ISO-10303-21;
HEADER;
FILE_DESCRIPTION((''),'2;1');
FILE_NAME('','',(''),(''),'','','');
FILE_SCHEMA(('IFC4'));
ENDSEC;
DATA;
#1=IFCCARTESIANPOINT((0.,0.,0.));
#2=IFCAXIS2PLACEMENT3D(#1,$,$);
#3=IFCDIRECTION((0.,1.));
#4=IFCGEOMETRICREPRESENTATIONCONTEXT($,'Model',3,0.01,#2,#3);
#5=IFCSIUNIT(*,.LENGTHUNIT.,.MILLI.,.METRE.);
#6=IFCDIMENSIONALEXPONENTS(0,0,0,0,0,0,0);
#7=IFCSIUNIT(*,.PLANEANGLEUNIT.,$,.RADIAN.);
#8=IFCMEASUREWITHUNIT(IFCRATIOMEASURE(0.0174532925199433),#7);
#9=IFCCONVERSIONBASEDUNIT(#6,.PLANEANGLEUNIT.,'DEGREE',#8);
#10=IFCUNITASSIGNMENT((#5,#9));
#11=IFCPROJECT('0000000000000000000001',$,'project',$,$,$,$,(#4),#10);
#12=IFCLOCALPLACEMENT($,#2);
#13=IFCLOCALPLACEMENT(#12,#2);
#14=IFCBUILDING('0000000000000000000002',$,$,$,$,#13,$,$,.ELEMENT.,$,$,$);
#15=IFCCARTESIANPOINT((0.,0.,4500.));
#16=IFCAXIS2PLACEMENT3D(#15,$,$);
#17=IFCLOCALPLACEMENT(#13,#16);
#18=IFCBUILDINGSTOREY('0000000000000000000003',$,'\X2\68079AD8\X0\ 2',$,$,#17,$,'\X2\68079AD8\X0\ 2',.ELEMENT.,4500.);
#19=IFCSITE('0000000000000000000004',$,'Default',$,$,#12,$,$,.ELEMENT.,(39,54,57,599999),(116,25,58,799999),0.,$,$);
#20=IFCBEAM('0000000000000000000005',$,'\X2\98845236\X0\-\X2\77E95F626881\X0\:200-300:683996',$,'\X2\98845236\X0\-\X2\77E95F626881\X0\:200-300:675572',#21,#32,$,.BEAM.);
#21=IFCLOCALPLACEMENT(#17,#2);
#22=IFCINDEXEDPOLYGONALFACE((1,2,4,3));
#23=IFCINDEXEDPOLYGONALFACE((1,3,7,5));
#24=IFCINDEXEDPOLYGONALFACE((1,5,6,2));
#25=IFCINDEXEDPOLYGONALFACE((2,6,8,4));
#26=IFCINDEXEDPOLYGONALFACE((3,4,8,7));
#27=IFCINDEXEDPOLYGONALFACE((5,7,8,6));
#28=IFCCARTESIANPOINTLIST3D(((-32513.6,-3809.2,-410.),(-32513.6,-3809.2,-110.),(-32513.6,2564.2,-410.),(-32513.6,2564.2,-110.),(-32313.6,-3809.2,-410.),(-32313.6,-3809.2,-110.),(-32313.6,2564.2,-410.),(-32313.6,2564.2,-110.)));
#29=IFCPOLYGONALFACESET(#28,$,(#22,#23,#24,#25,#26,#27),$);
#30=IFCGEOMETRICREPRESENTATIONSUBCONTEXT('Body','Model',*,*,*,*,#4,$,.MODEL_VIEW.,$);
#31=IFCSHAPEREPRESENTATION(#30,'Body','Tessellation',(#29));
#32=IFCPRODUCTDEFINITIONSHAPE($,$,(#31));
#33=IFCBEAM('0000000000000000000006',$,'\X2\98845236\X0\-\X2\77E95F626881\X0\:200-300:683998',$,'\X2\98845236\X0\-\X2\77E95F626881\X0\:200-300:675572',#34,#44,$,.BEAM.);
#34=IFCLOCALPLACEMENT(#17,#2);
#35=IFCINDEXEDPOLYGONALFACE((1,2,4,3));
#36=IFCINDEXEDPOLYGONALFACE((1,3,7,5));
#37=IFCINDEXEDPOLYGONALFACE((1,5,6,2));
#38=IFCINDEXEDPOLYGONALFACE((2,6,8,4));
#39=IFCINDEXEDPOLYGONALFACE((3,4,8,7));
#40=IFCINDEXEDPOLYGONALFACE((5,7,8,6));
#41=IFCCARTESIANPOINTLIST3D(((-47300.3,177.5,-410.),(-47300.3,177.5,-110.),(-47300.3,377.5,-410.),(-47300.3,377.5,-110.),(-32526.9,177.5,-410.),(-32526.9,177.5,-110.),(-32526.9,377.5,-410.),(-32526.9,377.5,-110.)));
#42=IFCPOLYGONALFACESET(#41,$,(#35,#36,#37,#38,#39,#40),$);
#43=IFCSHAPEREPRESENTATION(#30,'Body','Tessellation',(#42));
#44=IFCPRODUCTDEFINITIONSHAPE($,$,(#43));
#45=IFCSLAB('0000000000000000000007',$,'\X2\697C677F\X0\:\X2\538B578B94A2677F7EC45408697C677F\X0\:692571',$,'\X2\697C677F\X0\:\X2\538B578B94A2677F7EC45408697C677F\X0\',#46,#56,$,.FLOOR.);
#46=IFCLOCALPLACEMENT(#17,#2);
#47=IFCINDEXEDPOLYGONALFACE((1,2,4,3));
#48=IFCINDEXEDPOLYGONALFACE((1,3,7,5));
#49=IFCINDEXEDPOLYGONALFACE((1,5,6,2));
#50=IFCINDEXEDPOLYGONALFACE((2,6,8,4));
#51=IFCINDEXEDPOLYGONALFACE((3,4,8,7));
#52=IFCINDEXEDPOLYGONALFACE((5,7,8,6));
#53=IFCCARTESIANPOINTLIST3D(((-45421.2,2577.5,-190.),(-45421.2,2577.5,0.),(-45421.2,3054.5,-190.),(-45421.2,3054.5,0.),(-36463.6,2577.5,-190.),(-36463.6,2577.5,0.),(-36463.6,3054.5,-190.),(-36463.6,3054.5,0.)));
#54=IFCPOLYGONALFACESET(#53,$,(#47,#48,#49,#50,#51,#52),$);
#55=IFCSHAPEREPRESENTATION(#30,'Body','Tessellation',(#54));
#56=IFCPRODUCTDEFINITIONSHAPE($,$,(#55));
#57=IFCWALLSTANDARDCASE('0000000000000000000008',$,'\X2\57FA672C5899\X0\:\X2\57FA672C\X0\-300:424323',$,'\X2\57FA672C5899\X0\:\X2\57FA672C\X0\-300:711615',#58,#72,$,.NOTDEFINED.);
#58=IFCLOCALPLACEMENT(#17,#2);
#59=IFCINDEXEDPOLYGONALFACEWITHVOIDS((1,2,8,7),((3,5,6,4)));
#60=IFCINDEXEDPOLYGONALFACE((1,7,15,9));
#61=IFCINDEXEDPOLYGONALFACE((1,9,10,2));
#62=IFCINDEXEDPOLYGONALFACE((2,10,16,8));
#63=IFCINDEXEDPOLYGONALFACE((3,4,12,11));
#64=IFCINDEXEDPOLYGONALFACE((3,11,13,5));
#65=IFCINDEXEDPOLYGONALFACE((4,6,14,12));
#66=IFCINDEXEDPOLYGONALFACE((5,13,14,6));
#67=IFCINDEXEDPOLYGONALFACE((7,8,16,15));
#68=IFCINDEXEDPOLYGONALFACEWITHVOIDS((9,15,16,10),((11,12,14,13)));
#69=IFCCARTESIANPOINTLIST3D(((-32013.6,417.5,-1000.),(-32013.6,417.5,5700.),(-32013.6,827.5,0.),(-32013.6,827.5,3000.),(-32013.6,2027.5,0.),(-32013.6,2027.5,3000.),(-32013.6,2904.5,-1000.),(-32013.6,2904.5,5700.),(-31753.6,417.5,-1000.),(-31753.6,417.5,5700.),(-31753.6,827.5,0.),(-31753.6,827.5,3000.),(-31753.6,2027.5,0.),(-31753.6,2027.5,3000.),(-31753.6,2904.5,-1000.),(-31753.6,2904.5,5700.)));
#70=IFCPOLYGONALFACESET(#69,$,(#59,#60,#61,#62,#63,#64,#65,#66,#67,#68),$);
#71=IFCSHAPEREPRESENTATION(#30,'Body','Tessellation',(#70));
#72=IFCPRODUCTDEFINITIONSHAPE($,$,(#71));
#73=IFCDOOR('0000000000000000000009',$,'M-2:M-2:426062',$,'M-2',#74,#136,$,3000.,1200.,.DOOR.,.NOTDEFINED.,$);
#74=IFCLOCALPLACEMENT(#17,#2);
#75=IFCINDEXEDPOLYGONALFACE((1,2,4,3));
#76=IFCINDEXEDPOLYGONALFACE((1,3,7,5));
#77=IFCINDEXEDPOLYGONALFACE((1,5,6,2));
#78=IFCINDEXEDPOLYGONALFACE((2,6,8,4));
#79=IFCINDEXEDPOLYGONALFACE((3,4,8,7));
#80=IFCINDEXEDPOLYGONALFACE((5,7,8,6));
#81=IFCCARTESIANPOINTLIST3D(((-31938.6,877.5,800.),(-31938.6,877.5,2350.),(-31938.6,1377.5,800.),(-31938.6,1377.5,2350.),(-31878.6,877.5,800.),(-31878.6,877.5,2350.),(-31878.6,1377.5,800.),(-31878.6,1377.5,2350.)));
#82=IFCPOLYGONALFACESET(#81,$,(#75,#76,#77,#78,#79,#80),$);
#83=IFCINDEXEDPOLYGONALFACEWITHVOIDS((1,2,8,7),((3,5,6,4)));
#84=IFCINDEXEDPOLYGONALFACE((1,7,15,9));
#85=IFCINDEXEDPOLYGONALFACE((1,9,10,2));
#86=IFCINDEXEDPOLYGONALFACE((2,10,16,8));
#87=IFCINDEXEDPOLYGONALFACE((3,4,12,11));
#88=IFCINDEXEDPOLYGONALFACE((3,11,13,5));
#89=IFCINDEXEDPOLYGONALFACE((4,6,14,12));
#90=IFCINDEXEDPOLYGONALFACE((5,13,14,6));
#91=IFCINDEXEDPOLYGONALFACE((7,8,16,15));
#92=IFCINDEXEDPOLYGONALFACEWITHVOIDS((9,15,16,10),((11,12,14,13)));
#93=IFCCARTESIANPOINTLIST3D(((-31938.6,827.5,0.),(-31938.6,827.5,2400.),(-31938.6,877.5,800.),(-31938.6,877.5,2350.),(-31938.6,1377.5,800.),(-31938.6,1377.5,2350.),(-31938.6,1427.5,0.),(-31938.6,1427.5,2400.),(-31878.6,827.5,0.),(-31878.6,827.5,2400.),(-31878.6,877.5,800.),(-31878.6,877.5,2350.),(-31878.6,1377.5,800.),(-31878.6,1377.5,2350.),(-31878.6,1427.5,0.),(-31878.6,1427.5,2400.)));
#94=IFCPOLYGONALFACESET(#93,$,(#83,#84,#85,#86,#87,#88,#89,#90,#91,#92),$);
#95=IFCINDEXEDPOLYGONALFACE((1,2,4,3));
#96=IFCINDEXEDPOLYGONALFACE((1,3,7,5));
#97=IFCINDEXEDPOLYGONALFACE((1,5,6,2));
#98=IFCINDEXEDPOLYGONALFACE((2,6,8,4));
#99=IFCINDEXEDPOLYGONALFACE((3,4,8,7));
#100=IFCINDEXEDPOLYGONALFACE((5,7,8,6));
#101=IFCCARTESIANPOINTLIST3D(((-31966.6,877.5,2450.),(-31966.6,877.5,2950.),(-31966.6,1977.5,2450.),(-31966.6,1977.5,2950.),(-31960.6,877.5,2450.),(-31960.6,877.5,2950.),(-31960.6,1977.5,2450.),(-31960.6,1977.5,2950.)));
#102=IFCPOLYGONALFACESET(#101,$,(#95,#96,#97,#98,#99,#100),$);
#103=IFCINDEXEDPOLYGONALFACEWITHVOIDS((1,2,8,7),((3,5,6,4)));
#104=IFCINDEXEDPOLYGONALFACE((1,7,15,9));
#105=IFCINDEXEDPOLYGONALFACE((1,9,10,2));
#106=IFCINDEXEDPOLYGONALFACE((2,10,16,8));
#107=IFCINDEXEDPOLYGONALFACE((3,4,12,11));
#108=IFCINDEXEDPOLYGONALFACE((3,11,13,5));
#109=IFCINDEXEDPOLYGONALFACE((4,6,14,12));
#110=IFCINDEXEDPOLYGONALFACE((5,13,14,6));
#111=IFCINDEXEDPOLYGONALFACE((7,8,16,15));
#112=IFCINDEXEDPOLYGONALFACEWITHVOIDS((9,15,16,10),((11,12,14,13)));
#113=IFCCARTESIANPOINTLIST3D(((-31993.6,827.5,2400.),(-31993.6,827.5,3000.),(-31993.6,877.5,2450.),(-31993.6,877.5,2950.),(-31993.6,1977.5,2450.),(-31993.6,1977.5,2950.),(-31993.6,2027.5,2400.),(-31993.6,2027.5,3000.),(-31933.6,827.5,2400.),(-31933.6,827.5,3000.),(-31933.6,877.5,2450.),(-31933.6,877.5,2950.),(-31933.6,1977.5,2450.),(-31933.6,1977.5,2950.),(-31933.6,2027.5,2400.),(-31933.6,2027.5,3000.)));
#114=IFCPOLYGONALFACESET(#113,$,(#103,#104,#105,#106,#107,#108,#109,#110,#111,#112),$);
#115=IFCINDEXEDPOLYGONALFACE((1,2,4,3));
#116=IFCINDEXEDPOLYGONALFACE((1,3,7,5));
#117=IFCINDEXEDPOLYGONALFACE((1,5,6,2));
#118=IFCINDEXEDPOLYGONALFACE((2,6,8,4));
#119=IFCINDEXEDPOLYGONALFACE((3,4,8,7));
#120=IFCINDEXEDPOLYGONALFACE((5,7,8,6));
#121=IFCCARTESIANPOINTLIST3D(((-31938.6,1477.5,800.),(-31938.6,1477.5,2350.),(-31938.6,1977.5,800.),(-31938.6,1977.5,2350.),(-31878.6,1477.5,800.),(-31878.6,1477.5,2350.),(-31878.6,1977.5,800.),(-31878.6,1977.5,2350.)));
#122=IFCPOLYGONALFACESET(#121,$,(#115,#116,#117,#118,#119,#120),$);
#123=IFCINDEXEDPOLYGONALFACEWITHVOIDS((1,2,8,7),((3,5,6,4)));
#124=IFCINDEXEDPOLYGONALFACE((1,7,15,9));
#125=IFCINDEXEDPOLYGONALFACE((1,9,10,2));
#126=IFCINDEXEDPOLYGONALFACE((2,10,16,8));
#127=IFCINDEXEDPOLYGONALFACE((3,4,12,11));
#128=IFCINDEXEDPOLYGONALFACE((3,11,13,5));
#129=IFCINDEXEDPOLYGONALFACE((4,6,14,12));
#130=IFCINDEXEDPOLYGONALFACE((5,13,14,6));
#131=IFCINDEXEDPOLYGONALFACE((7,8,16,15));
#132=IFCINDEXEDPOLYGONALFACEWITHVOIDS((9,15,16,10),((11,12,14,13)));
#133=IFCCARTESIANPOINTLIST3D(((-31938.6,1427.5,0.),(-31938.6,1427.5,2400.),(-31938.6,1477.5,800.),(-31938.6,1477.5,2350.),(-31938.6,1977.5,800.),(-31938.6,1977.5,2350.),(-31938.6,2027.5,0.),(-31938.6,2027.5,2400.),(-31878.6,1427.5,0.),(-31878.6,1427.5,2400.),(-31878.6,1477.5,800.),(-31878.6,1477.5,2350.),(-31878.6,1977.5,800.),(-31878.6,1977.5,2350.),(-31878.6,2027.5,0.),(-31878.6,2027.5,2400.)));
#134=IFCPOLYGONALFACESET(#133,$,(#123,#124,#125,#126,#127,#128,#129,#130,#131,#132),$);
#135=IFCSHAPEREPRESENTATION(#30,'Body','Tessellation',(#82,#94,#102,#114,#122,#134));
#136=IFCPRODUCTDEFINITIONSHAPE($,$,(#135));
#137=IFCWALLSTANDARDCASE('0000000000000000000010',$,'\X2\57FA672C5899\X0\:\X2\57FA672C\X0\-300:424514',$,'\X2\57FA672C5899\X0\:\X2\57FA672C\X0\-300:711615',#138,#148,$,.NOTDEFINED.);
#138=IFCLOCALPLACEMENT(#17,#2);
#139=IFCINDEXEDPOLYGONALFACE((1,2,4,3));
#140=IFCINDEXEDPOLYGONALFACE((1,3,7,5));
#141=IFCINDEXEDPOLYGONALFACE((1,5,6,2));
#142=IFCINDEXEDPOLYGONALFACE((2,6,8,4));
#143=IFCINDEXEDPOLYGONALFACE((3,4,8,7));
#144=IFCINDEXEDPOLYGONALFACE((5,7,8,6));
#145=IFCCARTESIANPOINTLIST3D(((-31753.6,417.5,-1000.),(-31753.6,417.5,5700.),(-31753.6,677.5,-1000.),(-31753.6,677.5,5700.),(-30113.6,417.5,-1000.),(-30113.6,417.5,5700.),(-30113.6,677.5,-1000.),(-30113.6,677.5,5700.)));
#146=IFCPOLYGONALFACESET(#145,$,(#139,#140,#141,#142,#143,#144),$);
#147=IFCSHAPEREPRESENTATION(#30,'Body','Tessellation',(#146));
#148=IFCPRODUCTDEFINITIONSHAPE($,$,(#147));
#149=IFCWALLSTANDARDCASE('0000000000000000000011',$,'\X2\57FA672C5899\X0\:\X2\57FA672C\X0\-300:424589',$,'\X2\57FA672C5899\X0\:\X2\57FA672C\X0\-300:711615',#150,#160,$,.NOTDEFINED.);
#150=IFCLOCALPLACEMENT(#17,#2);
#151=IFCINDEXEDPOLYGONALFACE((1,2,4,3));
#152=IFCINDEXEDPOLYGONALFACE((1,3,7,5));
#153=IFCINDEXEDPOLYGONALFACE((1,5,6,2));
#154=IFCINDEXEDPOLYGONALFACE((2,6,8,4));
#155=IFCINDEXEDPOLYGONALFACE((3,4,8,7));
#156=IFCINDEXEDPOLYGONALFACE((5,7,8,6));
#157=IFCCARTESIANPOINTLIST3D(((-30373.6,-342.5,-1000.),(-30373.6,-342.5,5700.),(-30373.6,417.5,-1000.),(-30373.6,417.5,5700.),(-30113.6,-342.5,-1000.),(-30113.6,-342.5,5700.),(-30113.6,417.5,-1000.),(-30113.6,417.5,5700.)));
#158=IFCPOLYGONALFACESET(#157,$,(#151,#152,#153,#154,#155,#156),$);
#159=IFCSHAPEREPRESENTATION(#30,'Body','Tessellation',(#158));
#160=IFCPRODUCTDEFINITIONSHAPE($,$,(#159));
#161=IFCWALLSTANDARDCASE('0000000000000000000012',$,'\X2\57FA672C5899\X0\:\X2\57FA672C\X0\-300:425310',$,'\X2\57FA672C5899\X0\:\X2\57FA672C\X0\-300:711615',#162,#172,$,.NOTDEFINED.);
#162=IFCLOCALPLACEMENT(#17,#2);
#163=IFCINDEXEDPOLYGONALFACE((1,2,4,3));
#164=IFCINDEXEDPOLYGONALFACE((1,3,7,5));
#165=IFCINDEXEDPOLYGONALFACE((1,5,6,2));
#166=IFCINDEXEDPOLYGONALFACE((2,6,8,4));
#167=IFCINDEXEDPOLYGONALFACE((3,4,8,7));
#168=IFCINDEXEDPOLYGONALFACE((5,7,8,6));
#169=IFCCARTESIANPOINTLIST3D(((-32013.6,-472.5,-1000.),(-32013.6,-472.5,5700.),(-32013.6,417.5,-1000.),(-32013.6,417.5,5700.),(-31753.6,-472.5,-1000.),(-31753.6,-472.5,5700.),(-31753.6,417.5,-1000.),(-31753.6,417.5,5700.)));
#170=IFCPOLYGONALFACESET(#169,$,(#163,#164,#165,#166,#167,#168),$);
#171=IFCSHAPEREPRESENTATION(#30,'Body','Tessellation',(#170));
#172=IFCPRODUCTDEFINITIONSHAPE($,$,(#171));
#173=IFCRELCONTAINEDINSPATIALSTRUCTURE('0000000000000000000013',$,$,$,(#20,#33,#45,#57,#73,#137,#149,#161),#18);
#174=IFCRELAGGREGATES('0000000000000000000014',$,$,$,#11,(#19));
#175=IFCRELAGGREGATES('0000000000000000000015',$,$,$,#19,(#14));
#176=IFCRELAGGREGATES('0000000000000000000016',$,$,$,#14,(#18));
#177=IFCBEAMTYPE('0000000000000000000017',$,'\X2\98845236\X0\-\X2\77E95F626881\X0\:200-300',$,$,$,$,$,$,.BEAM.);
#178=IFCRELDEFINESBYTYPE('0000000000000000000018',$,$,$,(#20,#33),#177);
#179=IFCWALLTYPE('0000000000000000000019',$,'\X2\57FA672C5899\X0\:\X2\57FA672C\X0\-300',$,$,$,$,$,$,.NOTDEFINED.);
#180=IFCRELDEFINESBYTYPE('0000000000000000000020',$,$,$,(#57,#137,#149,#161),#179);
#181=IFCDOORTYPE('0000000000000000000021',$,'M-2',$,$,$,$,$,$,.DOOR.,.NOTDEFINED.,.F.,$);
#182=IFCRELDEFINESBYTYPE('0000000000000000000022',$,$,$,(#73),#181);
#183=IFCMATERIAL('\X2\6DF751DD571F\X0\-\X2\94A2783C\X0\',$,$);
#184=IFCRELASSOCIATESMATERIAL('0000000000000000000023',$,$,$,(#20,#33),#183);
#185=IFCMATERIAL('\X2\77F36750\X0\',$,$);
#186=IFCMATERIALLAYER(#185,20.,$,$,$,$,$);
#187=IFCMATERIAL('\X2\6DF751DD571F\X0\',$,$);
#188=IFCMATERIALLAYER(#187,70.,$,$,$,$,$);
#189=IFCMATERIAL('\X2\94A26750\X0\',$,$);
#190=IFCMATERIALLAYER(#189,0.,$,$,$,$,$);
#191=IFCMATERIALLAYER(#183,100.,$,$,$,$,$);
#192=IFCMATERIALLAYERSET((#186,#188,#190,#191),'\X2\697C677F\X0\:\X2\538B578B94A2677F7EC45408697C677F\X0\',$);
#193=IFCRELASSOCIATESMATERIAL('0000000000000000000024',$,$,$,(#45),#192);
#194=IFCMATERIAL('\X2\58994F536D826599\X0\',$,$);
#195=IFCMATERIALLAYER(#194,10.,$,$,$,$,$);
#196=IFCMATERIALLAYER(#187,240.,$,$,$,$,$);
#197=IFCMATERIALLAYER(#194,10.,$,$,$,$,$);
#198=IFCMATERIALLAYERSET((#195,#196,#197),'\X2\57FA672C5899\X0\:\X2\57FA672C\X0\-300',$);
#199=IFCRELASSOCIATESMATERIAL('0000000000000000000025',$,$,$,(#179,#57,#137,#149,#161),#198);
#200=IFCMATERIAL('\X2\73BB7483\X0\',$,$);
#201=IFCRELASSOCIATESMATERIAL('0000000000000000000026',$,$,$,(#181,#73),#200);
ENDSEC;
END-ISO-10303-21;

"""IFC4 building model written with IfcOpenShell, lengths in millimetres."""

from ifc_helpers import new_model, entity, si_unit, converted_unit, direction, frame, frame_2d, origin, origin_2d_with_axis, place, context, subcontext, project, spatial, polyline, rectangle, outline, extrude, source, transform, mapped, material, layer, layer_set, layer_usage, type_object, type_shapes, element, fill, save


model = new_model("IFC4")

# Units and contexts
model_context = context("Model", 3, precision=0.01, world=origin(), true_north=direction((0.0, 1.0)))
body_context = subcontext(model_context, "Body", "Model", "MODEL_VIEW")
ifc_project = project(units=[si_unit("LENGTHUNIT", "METRE", prefix="MILLI"), converted_unit("PLANEANGLEUNIT", "DEGREE", entity("IfcRatioMeasure", 0.0174532925199433), si_unit("PLANEANGLEUNIT", "RADIAN"), dimensions=[0, 0, 0, 0, 0, 0, 0])], contexts=[model_context])

# Site, building, storey
site_placement = place(None, origin())
site = spatial("IfcSite", under=ifc_project, at=site_placement, Name="Default", CompositionType="ELEMENT", RefLatitude=(39, 54, 57, 599999), RefLongitude=(116, 25, 58, 799999), RefElevation=0.0)
building_placement = place(site_placement, origin())
building = spatial("IfcBuilding", under=site, at=building_placement, CompositionType="ELEMENT")
storey_placement = place(building_placement, frame((0.0, 0.0, 4500.0)))
storey = spatial("IfcBuildingStorey", under=building, at=storey_placement, Name="标高 2", LongName="标高 2", CompositionType="ELEMENT", Elevation=4500.0)

# Beams
ifc_material_1 = material(Name="混凝土-钢砼")
beam_type = type_object("IfcBeamType", Name="预制-矩形梁:200-300", PredefinedType="BEAM")
beam_1_placement = place(storey_placement, frame((-32413.6, 2677.5, -110.0), z_axis=(0.0, 0.0, 1.0), x_axis=(0.0, -1.0, 0.0)))
element("IfcBeam", 1, at=beam_1_placement, inside=storey, type_object=beam_type, material=ifc_material_1, Name="预制-矩形梁:200-300:683996", ObjectType="预制-矩形梁:200-300:675572", PredefinedType="BEAM", context=body_context, shape_type="SweptSolid", body=[
    extrude(rectangle(XDim=300.0, YDim=200.0, at=frame_2d((0.0, 0.0), x_axis=(1.0, 0.0))), frame((113.3, 0.0, -150.0), z_axis=(1.0, 0.0, 0.0), x_axis=(0.0, 0.0, -1.0)), (0.0, 0.0, 1.0), 6373.4),
])
beam_2_placement = place(storey_placement, frame((-32413.6, 277.5, -110.0), z_axis=(0.0, 0.0, 1.0), x_axis=(-1.0, 0.0, 0.0)))
element("IfcBeam", 2, at=beam_2_placement, inside=storey, type_object=beam_type, material=ifc_material_1, Name="预制-矩形梁:200-300:683998", ObjectType="预制-矩形梁:200-300:675572", PredefinedType="BEAM", context=body_context, shape_type="SweptSolid", body=[
    extrude(rectangle(XDim=300.0, YDim=200.0, at=frame_2d((0.0, 0.0), x_axis=(1.0, 0.0))), frame((113.3, 0.0, -150.0), z_axis=(1.0, 0.0, 0.0), x_axis=(0.0, 0.0, -1.0)), (0.0, 0.0, 1.0), 14773.4),
])

# Slab
ifc_material_2 = material(Name="石材")
ifc_layer_1 = layer(ifc_material_2, 20.0)
ifc_material_3 = material(Name="混凝土")
ifc_layer_2 = layer(ifc_material_3, 70.0)
ifc_material_4 = material(Name="钢材")
ifc_layer_3 = layer(ifc_material_4, 0.0)
ifc_layer_4 = layer(ifc_material_1, 100.0)
ifc_layer_set_1 = layer_set([ifc_layer_1, ifc_layer_2, ifc_layer_3, ifc_layer_4], Name="楼板:压型钢板组合楼板")
ifc_layer_usage_1 = layer_usage(ifc_layer_set_1, "AXIS3", "POSITIVE", 0.0)
slab_1_placement = place(storey_placement, origin())
element("IfcSlab", 3, at=slab_1_placement, inside=storey, material=ifc_layer_usage_1, Name="楼板:压型钢板组合楼板:692571", ObjectType="楼板:压型钢板组合楼板", PredefinedType="FLOOR", context=body_context, shape_type="SweptSolid", body=[
    extrude(rectangle(XDim=477.0, YDim=8957.6, at=frame_2d((0.0, 0.0), x_axis=(1.0, 0.0))), frame((-40942.4, 2816.0, 0.0), z_axis=(0.0, 0.0, -1.0), x_axis=(0.0, 1.0, 0.0)), (0.0, 0.0, 1.0), 190.0),
])

# Wall, opening, door
ifc_material_5 = material(Name="墙体涂料")
ifc_layer_5 = layer(ifc_material_5, 10.0)
ifc_layer_6 = layer(ifc_material_3, 240.0)
ifc_layer_7 = layer(ifc_material_5, 10.0)
ifc_layer_set_2 = layer_set([ifc_layer_5, ifc_layer_6, ifc_layer_7], Name="基本墙:基本-300")
ifc_layer_usage_2 = layer_usage(ifc_layer_set_2, "AXIS2", "POSITIVE", -130.0)
wall_type = type_object("IfcWallType", Name="基本墙:基本-300", PredefinedType="NOTDEFINED", material=ifc_layer_set_2)
wall_1_placement = place(storey_placement, frame((-31883.6, 2904.5, -1000.0), z_axis=(0.0, 0.0, 1.0), x_axis=(0.0, -1.0, 0.0)))
wall_1 = element("IfcWallStandardCase", 4, at=wall_1_placement, inside=storey, type_object=wall_type, material=ifc_layer_usage_2, Name="基本墙:基本-300:424323", ObjectType="基本墙:基本-300:711615", PredefinedType="NOTDEFINED", context=body_context, shape_type="SweptSolid", body=[
    extrude(rectangle(XDim=2487.0, YDim=260.0, at=frame_2d((1243.5, 0.0), x_axis=(-1.0, 0.0))), origin(), (0.0, 0.0, 1.0), 6700.0),
])
opening_1_placement = place(wall_1_placement, frame((877.0, -130.0, 1000.0)))
opening_1 = element("IfcOpeningElement", 5, at=opening_1_placement, cuts=wall_1, ObjectType="Opening", PredefinedType="OPENING", context=body_context, shape_type="SweptSolid", body=[
    extrude(rectangle(XDim=3000.0, YDim=1200.0, at=frame_2d((1500.0, 600.0), x_axis=(1.0, 0.0))), frame((0.0, 0.0, 0.0), z_axis=(0.0, 1.0, 0.0), x_axis=(0.0, 0.0, 1.0)), (0.0, 0.0, 1.0), 260.0),
])
ifc_material_6 = material(Name="玻璃")
door_type = type_object("IfcDoorType", Name="M-2", OperationType="NOTDEFINED", ParameterTakesPrecedence=False, PredefinedType="DOOR", material=ifc_material_6)
shared_shape_1 = source(origin(), body_context, "Body", "SweptSolid", [
    extrude(rectangle(XDim=60.0, YDim=500.0, at=origin_2d_with_axis()), frame((900.0, 105.0, 800.0), z_axis=(0.0, 0.0, 1.0), x_axis=(0.0, -1.0, 0.0)), (0.0, 0.0, 1.0), 1550.0),
    extrude(outline(polyline([(-300.0, -1200.0), (300.0, -1200.0), (300.0, 1200.0), (-300.0, 1200.0), (-300.0, -1200.0)]), holes=[polyline([(250.0, -1150.0), (-250.0, -1150.0), (-250.0, 400.0), (250.0, 400.0), (250.0, -1150.0)])]), frame((900.0, 75.0, 1200.0), z_axis=(0.0, 1.0, 0.0), x_axis=(1.0, 0.0, 0.0)), (0.0, 0.0, 1.0), 60.0),
    extrude(rectangle(XDim=6.0, YDim=1100.0, at=frame_2d((0.0, 0.0), x_axis=(1.0, 0.0))), frame((600.0, 50.0, 2450.0), z_axis=(0.0, 0.0, 1.0), x_axis=(0.0, -1.0, 0.0)), (0.0, 0.0, 1.0), 500.0),
    extrude(outline(polyline([(-600.0, -300.0), (600.0, -300.0), (600.0, 300.0), (-600.0, 300.0), (-600.0, -300.0)]), holes=[polyline([(-550.0, -250.0), (-550.0, 250.0), (550.0, 250.0), (550.0, -250.0), (-550.0, -250.0)])]), frame((600.0, 20.0, 2700.0), z_axis=(0.0, 1.0, 0.0), x_axis=(1.0, 0.0, 0.0)), (0.0, 0.0, 1.0), 60.0),
    extrude(rectangle(XDim=500.0, YDim=60.0, at=frame_2d((0.0, 0.0), x_axis=(1.0, 0.0))), frame((300.0, 105.0, 800.0), z_axis=(0.0, 0.0, 1.0), x_axis=(-1.0, 0.0, 0.0)), (0.0, 0.0, 1.0), 1550.0),
    extrude(outline(polyline([(-1200.0, -300.0), (1200.0, -300.0), (1200.0, 300.0), (-1200.0, 300.0), (-1200.0, -300.0)]), holes=[polyline([(-1150.0, 250.0), (400.0, 250.0), (400.0, -250.0), (-1150.0, -250.0), (-1150.0, 250.0)])]), frame((300.0, 75.0, 1200.0), z_axis=(0.0, 1.0, 0.0), x_axis=(0.0, 0.0, -1.0)), (0.0, 0.0, 1.0), 60.0),
])
type_shapes(door_type, [shared_shape_1])
door_placement = place(opening_1_placement, origin())
door = element("IfcDoor", 6, at=door_placement, inside=storey, type_object=door_type, material=ifc_material_6, Name="M-2:M-2:426062", ObjectType="M-2", OperationType="NOTDEFINED", OverallHeight=3000.0, OverallWidth=1200.0, PredefinedType="DOOR", context=body_context, shape_type="MappedRepresentation", body=[
    mapped(shared_shape_1, transform((0.0, 0.0, 0.0), scale=1.0)),
])
fill(opening_1, door)

# Walls
ifc_layer_usage_3 = layer_usage(ifc_layer_set_2, "AXIS2", "NEGATIVE", 130.0)
wall_2_placement = place(storey_placement, frame((-31753.6, 547.5, -1000.0)))
element("IfcWallStandardCase", 7, at=wall_2_placement, inside=storey, type_object=wall_type, material=ifc_layer_usage_3, Name="基本墙:基本-300:424514", ObjectType="基本墙:基本-300:711615", PredefinedType="NOTDEFINED", context=body_context, shape_type="SweptSolid", body=[
    extrude(rectangle(XDim=1640.0, YDim=260.0, at=frame_2d((820.0, 0.0), x_axis=(-1.0, 0.0))), origin(), (0.0, 0.0, 1.0), 6700.0),
])
ifc_layer_usage_4 = layer_usage(ifc_layer_set_2, "AXIS2", "NEGATIVE", 130.0)
wall_3_placement = place(storey_placement, frame((-30243.6, 417.5, -1000.0), z_axis=(0.0, 0.0, 1.0), x_axis=(0.0, -1.0, 0.0)))
element("IfcWallStandardCase", 8, at=wall_3_placement, inside=storey, type_object=wall_type, material=ifc_layer_usage_4, Name="基本墙:基本-300:424589", ObjectType="基本墙:基本-300:711615", PredefinedType="NOTDEFINED", context=body_context, shape_type="SweptSolid", body=[
    extrude(rectangle(XDim=760.0, YDim=260.0, at=frame_2d((380.0, 0.0), x_axis=(-1.0, 0.0))), origin(), (0.0, 0.0, 1.0), 6700.0),
])
ifc_layer_usage_5 = layer_usage(ifc_layer_set_2, "AXIS2", "POSITIVE", -130.0)
wall_4_placement = place(storey_placement, frame((-31883.6, 417.5, -1000.0), z_axis=(0.0, 0.0, 1.0), x_axis=(0.0, -1.0, 0.0)))
element("IfcWallStandardCase", 9, at=wall_4_placement, inside=storey, type_object=wall_type, material=ifc_layer_usage_5, Name="基本墙:基本-300:425310", ObjectType="基本墙:基本-300:711615", PredefinedType="NOTDEFINED", context=body_context, shape_type="SweptSolid", body=[
    extrude(rectangle(XDim=890.0, YDim=260.0, at=frame_2d((445.0, 0.0), x_axis=(-1.0, 0.0))), origin(), (0.0, 0.0, 1.0), 6700.0),
])

save(model, "model.ifc")
